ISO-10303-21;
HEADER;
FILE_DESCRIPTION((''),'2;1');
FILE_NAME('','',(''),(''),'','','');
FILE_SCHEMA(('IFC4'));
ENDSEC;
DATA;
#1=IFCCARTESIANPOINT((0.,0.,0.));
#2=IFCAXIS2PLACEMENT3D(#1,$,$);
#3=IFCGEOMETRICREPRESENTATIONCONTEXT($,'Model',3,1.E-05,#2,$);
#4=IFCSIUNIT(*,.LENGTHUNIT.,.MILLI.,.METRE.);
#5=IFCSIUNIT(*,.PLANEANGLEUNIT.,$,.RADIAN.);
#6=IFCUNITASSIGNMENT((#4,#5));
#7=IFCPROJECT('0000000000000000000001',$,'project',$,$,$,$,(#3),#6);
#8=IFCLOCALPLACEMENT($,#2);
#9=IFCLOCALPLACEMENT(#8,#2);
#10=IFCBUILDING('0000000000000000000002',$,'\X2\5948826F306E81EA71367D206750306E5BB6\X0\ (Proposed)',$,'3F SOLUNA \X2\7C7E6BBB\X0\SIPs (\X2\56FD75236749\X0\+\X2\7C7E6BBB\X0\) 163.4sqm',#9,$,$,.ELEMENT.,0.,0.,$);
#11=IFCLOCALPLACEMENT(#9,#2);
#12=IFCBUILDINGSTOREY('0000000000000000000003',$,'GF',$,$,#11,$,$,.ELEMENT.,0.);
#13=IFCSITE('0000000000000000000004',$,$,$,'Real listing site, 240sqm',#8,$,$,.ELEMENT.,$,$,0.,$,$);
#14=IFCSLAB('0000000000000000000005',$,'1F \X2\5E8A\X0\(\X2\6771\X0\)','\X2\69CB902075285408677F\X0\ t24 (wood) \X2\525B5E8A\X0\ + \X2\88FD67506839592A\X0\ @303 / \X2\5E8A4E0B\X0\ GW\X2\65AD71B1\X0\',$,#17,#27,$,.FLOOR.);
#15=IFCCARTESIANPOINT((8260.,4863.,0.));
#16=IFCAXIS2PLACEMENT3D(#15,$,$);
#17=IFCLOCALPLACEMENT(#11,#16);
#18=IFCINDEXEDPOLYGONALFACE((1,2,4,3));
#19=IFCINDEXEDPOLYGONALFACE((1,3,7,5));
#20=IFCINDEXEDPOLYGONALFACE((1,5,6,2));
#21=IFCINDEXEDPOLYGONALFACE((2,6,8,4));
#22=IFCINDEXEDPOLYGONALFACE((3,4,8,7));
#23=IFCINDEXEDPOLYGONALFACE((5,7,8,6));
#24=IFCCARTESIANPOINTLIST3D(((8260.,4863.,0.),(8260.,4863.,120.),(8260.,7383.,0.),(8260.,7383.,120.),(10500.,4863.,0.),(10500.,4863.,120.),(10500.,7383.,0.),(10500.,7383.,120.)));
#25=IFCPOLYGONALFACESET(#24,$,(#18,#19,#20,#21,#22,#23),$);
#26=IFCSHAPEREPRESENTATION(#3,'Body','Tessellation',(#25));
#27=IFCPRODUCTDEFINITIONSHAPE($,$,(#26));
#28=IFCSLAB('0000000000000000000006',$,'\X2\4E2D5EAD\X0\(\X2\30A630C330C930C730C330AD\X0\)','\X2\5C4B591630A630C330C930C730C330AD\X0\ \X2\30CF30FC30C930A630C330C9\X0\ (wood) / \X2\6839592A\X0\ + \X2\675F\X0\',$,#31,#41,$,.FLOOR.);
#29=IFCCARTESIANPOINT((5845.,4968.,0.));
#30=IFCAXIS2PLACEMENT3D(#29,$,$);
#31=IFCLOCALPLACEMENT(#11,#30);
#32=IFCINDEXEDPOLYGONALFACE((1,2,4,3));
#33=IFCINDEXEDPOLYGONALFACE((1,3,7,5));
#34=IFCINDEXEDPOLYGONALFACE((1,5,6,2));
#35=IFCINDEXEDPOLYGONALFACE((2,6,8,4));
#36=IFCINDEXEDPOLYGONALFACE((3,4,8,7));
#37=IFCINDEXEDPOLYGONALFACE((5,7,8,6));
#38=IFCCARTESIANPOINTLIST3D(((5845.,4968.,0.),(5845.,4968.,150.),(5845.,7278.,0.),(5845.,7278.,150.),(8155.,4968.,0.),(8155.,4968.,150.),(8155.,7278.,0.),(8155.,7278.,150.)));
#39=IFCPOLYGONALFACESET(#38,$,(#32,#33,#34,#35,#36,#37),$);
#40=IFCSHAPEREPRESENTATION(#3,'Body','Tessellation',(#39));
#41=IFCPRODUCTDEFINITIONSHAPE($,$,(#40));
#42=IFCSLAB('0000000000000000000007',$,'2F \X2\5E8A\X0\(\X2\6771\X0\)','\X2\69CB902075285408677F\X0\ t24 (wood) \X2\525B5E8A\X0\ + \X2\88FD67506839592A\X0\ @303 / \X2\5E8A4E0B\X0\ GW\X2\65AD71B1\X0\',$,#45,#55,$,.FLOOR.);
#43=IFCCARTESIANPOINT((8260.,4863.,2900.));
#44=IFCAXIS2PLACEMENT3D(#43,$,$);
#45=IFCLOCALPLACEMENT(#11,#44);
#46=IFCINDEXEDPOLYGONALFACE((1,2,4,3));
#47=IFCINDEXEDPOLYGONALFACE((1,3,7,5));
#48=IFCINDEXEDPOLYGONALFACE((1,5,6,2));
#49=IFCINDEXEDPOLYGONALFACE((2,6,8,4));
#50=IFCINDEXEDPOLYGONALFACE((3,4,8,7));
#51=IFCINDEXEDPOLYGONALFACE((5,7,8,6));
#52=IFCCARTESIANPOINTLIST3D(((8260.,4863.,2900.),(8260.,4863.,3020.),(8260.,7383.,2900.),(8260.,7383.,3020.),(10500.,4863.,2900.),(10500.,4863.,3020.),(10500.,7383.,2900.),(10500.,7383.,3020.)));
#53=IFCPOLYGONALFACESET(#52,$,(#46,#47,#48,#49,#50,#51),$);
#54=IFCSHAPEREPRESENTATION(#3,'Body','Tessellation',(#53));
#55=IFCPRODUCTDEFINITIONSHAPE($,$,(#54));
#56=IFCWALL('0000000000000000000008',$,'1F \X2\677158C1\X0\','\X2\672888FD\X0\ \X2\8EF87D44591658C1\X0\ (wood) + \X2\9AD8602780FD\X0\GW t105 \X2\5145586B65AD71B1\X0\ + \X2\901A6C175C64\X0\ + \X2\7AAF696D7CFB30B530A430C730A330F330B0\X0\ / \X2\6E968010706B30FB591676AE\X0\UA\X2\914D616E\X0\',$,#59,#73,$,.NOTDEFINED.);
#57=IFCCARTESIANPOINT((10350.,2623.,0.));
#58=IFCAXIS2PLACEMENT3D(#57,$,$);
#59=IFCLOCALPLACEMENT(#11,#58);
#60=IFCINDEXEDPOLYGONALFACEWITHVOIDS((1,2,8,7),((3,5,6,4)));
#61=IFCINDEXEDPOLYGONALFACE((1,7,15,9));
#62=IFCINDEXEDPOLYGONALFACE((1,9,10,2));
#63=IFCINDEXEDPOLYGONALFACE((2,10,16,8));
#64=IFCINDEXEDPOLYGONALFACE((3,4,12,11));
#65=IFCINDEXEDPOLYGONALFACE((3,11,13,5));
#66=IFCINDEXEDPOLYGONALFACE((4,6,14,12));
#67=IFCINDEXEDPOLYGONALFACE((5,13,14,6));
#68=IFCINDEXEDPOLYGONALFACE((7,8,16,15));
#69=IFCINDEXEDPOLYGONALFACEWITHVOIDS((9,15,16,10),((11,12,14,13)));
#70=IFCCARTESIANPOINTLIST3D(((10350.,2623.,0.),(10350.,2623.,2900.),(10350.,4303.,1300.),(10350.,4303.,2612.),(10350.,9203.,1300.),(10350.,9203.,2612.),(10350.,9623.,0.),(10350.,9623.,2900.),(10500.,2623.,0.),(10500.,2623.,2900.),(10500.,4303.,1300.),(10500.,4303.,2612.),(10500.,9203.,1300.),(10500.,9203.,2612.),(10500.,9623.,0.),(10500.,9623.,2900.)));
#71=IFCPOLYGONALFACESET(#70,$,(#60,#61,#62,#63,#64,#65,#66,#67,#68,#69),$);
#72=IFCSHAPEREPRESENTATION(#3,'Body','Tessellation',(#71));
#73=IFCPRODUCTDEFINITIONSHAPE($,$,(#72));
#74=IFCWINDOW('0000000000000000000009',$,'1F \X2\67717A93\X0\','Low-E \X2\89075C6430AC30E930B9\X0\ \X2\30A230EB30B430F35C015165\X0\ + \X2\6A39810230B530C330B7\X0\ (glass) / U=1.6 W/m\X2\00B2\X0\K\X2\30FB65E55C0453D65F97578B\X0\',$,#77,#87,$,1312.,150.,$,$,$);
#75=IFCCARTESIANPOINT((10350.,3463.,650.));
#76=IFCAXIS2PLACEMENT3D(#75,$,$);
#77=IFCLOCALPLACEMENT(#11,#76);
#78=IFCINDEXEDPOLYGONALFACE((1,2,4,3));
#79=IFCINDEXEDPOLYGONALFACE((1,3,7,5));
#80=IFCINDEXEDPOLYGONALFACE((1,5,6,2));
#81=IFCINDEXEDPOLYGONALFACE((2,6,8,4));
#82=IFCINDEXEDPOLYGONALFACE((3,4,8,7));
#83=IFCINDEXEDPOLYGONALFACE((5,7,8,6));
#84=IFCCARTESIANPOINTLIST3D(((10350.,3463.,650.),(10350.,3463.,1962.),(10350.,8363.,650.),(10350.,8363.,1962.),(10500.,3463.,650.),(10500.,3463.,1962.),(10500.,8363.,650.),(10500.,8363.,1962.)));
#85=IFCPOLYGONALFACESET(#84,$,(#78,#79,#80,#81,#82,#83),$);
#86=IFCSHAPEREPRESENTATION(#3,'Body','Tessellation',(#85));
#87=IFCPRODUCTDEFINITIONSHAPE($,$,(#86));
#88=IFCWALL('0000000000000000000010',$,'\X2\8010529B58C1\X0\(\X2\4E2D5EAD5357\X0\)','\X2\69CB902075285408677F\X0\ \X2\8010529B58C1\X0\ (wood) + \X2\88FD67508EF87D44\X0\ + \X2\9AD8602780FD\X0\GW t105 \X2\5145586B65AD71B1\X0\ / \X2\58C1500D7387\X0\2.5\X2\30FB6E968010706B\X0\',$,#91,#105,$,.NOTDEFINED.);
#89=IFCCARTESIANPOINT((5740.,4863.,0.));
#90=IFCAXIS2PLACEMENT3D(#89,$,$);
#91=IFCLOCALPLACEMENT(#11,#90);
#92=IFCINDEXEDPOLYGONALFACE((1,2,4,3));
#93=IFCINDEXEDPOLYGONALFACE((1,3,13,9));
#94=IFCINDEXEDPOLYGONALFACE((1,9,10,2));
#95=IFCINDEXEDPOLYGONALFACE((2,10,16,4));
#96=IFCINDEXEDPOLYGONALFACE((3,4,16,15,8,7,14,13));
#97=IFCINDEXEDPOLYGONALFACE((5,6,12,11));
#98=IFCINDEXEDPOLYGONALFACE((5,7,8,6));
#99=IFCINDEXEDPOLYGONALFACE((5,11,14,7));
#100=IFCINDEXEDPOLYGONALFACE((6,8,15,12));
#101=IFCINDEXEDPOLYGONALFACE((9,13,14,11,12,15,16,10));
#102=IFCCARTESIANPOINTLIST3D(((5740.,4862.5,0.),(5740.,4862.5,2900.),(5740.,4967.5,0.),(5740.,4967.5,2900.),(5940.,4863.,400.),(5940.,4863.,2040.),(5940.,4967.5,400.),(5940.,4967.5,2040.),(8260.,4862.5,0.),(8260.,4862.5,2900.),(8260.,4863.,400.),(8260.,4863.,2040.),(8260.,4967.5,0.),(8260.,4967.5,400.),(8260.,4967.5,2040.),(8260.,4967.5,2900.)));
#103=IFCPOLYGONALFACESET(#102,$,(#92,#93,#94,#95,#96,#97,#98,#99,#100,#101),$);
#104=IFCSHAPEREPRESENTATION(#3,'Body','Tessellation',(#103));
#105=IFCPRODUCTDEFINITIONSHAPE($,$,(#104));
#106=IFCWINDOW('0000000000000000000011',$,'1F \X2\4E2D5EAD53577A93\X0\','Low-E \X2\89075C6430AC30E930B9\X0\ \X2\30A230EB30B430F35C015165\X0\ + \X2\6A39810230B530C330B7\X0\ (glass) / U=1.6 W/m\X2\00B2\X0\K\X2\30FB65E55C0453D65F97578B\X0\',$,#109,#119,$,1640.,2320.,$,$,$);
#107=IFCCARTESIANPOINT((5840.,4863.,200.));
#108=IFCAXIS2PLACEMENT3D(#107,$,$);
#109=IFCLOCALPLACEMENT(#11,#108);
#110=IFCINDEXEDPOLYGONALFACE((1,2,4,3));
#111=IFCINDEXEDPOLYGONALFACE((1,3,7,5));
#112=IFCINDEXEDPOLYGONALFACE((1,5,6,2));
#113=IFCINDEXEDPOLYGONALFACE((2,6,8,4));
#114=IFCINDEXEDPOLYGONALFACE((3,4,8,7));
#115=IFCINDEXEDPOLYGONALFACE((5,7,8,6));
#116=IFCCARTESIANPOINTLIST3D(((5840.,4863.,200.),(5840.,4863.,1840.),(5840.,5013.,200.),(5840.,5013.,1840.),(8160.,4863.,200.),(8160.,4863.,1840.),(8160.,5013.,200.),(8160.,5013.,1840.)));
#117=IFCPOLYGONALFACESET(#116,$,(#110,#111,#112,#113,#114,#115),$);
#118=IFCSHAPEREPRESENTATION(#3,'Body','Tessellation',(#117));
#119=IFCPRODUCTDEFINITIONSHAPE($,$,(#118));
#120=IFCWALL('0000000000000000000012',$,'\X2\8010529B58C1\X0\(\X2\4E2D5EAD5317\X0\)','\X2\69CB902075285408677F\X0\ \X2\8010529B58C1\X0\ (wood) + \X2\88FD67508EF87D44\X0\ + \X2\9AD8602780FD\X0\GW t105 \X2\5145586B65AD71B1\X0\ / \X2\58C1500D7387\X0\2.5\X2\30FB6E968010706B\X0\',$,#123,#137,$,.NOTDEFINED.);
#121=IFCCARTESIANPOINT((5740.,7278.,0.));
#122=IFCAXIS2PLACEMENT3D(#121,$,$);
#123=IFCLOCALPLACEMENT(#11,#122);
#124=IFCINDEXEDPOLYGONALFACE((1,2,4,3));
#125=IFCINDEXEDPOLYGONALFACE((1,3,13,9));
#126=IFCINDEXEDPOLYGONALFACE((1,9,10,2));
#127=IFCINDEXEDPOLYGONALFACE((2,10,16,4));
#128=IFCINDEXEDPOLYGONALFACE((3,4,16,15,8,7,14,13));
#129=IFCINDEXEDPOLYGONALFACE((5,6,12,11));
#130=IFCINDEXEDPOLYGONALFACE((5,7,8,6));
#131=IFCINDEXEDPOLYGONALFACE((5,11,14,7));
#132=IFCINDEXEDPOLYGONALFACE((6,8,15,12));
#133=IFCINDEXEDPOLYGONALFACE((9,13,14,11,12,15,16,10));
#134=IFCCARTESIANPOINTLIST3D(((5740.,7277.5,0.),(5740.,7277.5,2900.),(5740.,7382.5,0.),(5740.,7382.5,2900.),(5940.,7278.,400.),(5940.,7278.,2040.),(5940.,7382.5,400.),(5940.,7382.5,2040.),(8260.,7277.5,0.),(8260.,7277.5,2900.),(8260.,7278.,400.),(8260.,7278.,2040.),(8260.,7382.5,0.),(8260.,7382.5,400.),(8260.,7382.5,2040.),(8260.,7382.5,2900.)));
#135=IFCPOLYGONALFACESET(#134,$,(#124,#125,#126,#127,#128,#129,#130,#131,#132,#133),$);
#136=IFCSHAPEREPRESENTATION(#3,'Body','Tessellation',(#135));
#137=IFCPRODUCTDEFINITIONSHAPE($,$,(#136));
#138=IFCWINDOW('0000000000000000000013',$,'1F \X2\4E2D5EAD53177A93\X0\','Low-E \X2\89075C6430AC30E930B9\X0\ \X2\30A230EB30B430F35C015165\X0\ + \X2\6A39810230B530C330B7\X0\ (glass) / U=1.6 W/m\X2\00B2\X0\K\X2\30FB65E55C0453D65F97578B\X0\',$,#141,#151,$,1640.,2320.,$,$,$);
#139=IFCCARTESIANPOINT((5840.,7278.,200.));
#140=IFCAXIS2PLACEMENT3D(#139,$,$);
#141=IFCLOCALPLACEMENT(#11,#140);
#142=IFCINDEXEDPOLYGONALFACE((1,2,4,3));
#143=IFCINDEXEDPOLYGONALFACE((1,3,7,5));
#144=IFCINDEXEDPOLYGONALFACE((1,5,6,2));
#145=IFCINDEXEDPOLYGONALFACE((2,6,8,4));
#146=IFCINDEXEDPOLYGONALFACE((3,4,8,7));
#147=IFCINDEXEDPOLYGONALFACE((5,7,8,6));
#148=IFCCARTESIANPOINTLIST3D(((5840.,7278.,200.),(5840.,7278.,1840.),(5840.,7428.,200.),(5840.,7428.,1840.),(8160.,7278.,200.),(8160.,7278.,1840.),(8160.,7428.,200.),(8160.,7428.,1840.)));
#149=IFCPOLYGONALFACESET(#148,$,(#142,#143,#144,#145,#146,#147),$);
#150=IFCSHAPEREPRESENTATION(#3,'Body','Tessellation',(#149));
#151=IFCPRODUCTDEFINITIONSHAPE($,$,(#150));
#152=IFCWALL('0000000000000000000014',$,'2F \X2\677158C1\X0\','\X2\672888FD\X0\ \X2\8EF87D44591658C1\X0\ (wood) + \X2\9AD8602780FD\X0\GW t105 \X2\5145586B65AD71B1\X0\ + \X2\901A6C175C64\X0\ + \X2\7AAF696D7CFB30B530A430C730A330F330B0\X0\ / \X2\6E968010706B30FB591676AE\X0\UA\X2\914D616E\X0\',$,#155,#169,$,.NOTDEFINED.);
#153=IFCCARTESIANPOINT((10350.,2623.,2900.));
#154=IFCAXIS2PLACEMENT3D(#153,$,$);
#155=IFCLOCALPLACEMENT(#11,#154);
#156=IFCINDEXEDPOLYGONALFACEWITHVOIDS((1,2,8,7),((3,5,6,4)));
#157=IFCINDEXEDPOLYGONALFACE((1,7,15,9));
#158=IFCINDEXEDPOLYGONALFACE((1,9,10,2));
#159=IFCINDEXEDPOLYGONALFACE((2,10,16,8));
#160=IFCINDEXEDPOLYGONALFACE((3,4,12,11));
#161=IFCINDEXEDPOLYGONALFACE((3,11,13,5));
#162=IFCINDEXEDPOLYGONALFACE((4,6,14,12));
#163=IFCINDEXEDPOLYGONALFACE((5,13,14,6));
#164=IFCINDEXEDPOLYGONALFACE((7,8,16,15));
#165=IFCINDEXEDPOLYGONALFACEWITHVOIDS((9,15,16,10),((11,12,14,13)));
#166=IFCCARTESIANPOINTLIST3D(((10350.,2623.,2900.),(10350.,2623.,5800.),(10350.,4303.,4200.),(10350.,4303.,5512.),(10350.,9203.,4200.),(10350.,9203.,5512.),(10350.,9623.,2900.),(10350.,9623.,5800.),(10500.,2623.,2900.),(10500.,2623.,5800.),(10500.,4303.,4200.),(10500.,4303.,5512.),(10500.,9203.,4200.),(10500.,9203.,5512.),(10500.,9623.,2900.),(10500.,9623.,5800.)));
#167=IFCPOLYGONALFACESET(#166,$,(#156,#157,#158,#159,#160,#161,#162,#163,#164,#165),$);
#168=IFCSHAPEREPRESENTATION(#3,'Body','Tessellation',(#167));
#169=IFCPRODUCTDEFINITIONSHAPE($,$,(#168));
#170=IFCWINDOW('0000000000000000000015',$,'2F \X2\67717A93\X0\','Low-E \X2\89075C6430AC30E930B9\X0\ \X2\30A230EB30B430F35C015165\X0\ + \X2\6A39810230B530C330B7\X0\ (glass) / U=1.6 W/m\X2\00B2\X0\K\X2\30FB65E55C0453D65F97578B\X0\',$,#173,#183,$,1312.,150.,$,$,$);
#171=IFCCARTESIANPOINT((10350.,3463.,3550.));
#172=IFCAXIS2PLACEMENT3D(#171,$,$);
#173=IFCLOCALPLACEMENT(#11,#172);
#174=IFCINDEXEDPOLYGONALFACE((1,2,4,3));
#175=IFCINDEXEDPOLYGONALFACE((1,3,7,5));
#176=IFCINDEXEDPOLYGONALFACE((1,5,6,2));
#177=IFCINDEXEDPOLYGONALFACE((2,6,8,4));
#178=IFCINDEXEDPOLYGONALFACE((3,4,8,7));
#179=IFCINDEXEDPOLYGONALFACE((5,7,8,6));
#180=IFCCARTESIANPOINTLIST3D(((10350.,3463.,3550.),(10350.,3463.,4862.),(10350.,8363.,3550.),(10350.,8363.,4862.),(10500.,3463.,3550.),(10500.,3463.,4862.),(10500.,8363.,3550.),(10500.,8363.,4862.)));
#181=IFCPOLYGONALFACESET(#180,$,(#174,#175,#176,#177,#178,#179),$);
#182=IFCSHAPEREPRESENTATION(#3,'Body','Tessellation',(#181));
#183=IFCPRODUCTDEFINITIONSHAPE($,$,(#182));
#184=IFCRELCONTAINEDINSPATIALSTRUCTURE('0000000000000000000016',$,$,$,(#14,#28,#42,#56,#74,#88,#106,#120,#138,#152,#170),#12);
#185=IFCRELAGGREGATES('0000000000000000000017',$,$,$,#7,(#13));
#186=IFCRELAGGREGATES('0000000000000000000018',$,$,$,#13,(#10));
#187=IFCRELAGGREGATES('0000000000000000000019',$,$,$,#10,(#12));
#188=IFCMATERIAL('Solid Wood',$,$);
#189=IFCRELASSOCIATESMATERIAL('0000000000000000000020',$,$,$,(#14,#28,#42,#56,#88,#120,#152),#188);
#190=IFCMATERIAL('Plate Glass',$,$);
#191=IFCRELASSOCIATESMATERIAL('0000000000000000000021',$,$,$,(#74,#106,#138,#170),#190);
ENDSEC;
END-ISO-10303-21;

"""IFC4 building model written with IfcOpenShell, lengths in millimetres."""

from ifc_helpers import new_model, si_unit, frame, frame_2d, origin, place, context, project, spatial, rectangle, extrude, material, element, fill, save


model = new_model("IFC4")

# Units and contexts
model_context = context("Model", 3, precision=1e-05, world=origin())
ifc_project = project(units=[si_unit("LENGTHUNIT", "METRE", prefix="MILLI"), si_unit("PLANEANGLEUNIT", "RADIAN")], contexts=[model_context])

# Site, building, storey
site_placement = place(None, origin())
site = spatial("IfcSite", under=ifc_project, at=site_placement, ObjectType="Real listing site, 240sqm", CompositionType="ELEMENT", RefElevation=0.0)
building_placement = place(site_placement, origin())
building = spatial("IfcBuilding", under=site, at=building_placement, Name="奈良の自然素材の家 (Proposed)", ObjectType="3F SOLUNA 籾殻SIPs (国産杉+籾殻) 163.4sqm", CompositionType="ELEMENT", ElevationOfRefHeight=0.0, ElevationOfTerrain=0.0)
storey_placement = place(building_placement, origin())
storey = spatial("IfcBuildingStorey", under=building, at=storey_placement, Name="GF", CompositionType="ELEMENT", Elevation=0.0)

# Slabs
ifc_material_1 = material(Name="Solid Wood")
slab_1_placement = place(storey_placement, frame((8260.0, 4863.0, 0.0)))
element("IfcSlab", 1, at=slab_1_placement, inside=storey, material=ifc_material_1, Name="1F 床(東)", Description="構造用合板 t24 (wood) 剛床 + 製材根太 @303 / 床下 GW断熱", PredefinedType="FLOOR", context=model_context, shape_type="SweptSolid", body=[
    extrude(rectangle(XDim=2240.0, YDim=2520.0, at=frame_2d((1120.0, 1260.0))), frame((8260.0, 4863.0, 0.0)), (0.0, 0.0, 1.0), 120.0),
])
slab_2_placement = place(storey_placement, frame((5845.0, 4968.0, 0.0)))
element("IfcSlab", 2, at=slab_2_placement, inside=storey, material=ifc_material_1, Name="中庭(ウッドデッキ)", Description="屋外ウッドデッキ ハードウッド (wood) / 根太 + 束", PredefinedType="FLOOR", context=model_context, shape_type="SweptSolid", body=[
    extrude(rectangle(XDim=2310.0, YDim=2310.0, at=frame_2d((1155.0, 1155.0))), frame((5845.0, 4968.0, 0.0)), (0.0, 0.0, 1.0), 150.0),
])
slab_3_placement = place(storey_placement, frame((8260.0, 4863.0, 2900.0)))
element("IfcSlab", 3, at=slab_3_placement, inside=storey, material=ifc_material_1, Name="2F 床(東)", Description="構造用合板 t24 (wood) 剛床 + 製材根太 @303 / 床下 GW断熱", PredefinedType="FLOOR", context=model_context, shape_type="SweptSolid", body=[
    extrude(rectangle(XDim=2240.0, YDim=2520.0, at=frame_2d((1120.0, 1260.0))), frame((8260.0, 4863.0, 2900.0)), (0.0, 0.0, 1.0), 120.0),
])

# Walls, openings, windows
wall_1_placement = place(storey_placement, frame((10350.0, 2623.0, 0.0)))
wall_1 = element("IfcWall", 4, at=wall_1_placement, inside=storey, material=ifc_material_1, Name="1F 東壁", Description="木製 軸組外壁 (wood) + 高性能GW t105 充填断熱 + 通気層 + 窯業系サイディング / 準耐火・外皮UA配慮", PredefinedType="NOTDEFINED", context=model_context, shape_type="SweptSolid", body=[
    extrude(rectangle(XDim=150.0, YDim=7000.0, at=frame_2d((75.0, 3500.0))), frame((10350.0, 2623.0, 0.0)), (0.0, 0.0, 1.0), 2900.0),
])
opening_1_placement = place(storey_placement, frame((10350.0, 3463.0, 650.0)))
opening_1 = element("IfcOpeningElement", 5, at=opening_1_placement, cuts=wall_1, PredefinedType="NOTDEFINED", context=model_context, shape_type="SweptSolid", body=[
    extrude(rectangle(XDim=150.0, YDim=4900.0, at=frame_2d((75.0, 2450.0))), frame((10350.0, 3463.0, 650.0)), (0.0, 0.0, 1.0), 1312.0),
])
ifc_material_2 = material(Name="Plate Glass")
window_1_placement = place(storey_placement, frame((10350.0, 3463.0, 650.0)))
window_1 = element("IfcWindow", 6, at=window_1_placement, inside=storey, material=ifc_material_2, Name="1F 東窓", Description="Low-E 複層ガラス アルゴン封入 + 樹脂サッシ (glass) / U=1.6 W/m²K・日射取得型", OverallHeight=1312.0, OverallWidth=150.0, context=model_context, shape_type="SweptSolid", body=[
    extrude(rectangle(XDim=150.0, YDim=4900.0, at=frame_2d((75.0, 2450.0))), frame((10350.0, 3463.0, 650.0)), (0.0, 0.0, 1.0), 1312.0),
])
fill(opening_1, window_1)
wall_2_placement = place(storey_placement, frame((5740.0, 4863.0, 0.0)))
wall_2 = element("IfcWall", 7, at=wall_2_placement, inside=storey, material=ifc_material_1, Name="耐力壁(中庭南)", Description="構造用合板 耐力壁 (wood) + 製材軸組 + 高性能GW t105 充填断熱 / 壁倍率2.5・準耐火", PredefinedType="NOTDEFINED", context=model_context, shape_type="SweptSolid", body=[
    extrude(rectangle(XDim=2520.0, YDim=105.0, at=frame_2d((1260.0, 52.0))), frame((5740.0, 4863.0, 0.0)), (0.0, 0.0, 1.0), 2900.0),
])
opening_2_placement = place(storey_placement, frame((5840.0, 4863.0, 200.0)))
opening_2 = element("IfcOpeningElement", 8, at=opening_2_placement, cuts=wall_2, PredefinedType="NOTDEFINED", context=model_context, shape_type="SweptSolid", body=[
    extrude(rectangle(XDim=2320.0, YDim=150.0, at=frame_2d((1160.0, 75.0))), frame((5840.0, 4863.0, 200.0)), (0.0, 0.0, 1.0), 1640.0),
])
window_2_placement = place(storey_placement, frame((5840.0, 4863.0, 200.0)))
window_2 = element("IfcWindow", 9, at=window_2_placement, inside=storey, material=ifc_material_2, Name="1F 中庭南窓", Description="Low-E 複層ガラス アルゴン封入 + 樹脂サッシ (glass) / U=1.6 W/m²K・日射取得型", OverallHeight=1640.0, OverallWidth=2320.0, context=model_context, shape_type="SweptSolid", body=[
    extrude(rectangle(XDim=2320.0, YDim=150.0, at=frame_2d((1160.0, 75.0))), frame((5840.0, 4863.0, 200.0)), (0.0, 0.0, 1.0), 1640.0),
])
fill(opening_2, window_2)
wall_3_placement = place(storey_placement, frame((5740.0, 7278.0, 0.0)))
wall_3 = element("IfcWall", 10, at=wall_3_placement, inside=storey, material=ifc_material_1, Name="耐力壁(中庭北)", Description="構造用合板 耐力壁 (wood) + 製材軸組 + 高性能GW t105 充填断熱 / 壁倍率2.5・準耐火", PredefinedType="NOTDEFINED", context=model_context, shape_type="SweptSolid", body=[
    extrude(rectangle(XDim=2520.0, YDim=105.0, at=frame_2d((1260.0, 52.0))), frame((5740.0, 7278.0, 0.0)), (0.0, 0.0, 1.0), 2900.0),
])
opening_3_placement = place(storey_placement, frame((5840.0, 7278.0, 200.0)))
opening_3 = element("IfcOpeningElement", 11, at=opening_3_placement, cuts=wall_3, PredefinedType="NOTDEFINED", context=model_context, shape_type="SweptSolid", body=[
    extrude(rectangle(XDim=2320.0, YDim=150.0, at=frame_2d((1160.0, 75.0))), frame((5840.0, 7278.0, 200.0)), (0.0, 0.0, 1.0), 1640.0),
])
window_3_placement = place(storey_placement, frame((5840.0, 7278.0, 200.0)))
window_3 = element("IfcWindow", 12, at=window_3_placement, inside=storey, material=ifc_material_2, Name="1F 中庭北窓", Description="Low-E 複層ガラス アルゴン封入 + 樹脂サッシ (glass) / U=1.6 W/m²K・日射取得型", OverallHeight=1640.0, OverallWidth=2320.0, context=model_context, shape_type="SweptSolid", body=[
    extrude(rectangle(XDim=2320.0, YDim=150.0, at=frame_2d((1160.0, 75.0))), frame((5840.0, 7278.0, 200.0)), (0.0, 0.0, 1.0), 1640.0),
])
fill(opening_3, window_3)

# Wall, opening, window
wall_4_placement = place(storey_placement, frame((10350.0, 2623.0, 2900.0)))
wall_4 = element("IfcWall", 13, at=wall_4_placement, inside=storey, material=ifc_material_1, Name="2F 東壁", Description="木製 軸組外壁 (wood) + 高性能GW t105 充填断熱 + 通気層 + 窯業系サイディング / 準耐火・外皮UA配慮", PredefinedType="NOTDEFINED", context=model_context, shape_type="SweptSolid", body=[
    extrude(rectangle(XDim=150.0, YDim=7000.0, at=frame_2d((75.0, 3500.0))), frame((10350.0, 2623.0, 2900.0)), (0.0, 0.0, 1.0), 2900.0),
])
opening_4_placement = place(storey_placement, frame((10350.0, 3463.0, 3550.0)))
opening_4 = element("IfcOpeningElement", 14, at=opening_4_placement, cuts=wall_4, PredefinedType="NOTDEFINED", context=model_context, shape_type="SweptSolid", body=[
    extrude(rectangle(XDim=150.0, YDim=4900.0, at=frame_2d((75.0, 2450.0))), frame((10350.0, 3463.0, 3550.0)), (0.0, 0.0, 1.0), 1312.0),
])
window_4_placement = place(storey_placement, frame((10350.0, 3463.0, 3550.0)))
window_4 = element("IfcWindow", 15, at=window_4_placement, inside=storey, material=ifc_material_2, Name="2F 東窓", Description="Low-E 複層ガラス アルゴン封入 + 樹脂サッシ (glass) / U=1.6 W/m²K・日射取得型", OverallHeight=1312.0, OverallWidth=150.0, context=model_context, shape_type="SweptSolid", body=[
    extrude(rectangle(XDim=150.0, YDim=4900.0, at=frame_2d((75.0, 2450.0))), frame((10350.0, 3463.0, 3550.0)), (0.0, 0.0, 1.0), 1312.0),
])
fill(opening_4, window_4)

save(model, "model.ifc")
